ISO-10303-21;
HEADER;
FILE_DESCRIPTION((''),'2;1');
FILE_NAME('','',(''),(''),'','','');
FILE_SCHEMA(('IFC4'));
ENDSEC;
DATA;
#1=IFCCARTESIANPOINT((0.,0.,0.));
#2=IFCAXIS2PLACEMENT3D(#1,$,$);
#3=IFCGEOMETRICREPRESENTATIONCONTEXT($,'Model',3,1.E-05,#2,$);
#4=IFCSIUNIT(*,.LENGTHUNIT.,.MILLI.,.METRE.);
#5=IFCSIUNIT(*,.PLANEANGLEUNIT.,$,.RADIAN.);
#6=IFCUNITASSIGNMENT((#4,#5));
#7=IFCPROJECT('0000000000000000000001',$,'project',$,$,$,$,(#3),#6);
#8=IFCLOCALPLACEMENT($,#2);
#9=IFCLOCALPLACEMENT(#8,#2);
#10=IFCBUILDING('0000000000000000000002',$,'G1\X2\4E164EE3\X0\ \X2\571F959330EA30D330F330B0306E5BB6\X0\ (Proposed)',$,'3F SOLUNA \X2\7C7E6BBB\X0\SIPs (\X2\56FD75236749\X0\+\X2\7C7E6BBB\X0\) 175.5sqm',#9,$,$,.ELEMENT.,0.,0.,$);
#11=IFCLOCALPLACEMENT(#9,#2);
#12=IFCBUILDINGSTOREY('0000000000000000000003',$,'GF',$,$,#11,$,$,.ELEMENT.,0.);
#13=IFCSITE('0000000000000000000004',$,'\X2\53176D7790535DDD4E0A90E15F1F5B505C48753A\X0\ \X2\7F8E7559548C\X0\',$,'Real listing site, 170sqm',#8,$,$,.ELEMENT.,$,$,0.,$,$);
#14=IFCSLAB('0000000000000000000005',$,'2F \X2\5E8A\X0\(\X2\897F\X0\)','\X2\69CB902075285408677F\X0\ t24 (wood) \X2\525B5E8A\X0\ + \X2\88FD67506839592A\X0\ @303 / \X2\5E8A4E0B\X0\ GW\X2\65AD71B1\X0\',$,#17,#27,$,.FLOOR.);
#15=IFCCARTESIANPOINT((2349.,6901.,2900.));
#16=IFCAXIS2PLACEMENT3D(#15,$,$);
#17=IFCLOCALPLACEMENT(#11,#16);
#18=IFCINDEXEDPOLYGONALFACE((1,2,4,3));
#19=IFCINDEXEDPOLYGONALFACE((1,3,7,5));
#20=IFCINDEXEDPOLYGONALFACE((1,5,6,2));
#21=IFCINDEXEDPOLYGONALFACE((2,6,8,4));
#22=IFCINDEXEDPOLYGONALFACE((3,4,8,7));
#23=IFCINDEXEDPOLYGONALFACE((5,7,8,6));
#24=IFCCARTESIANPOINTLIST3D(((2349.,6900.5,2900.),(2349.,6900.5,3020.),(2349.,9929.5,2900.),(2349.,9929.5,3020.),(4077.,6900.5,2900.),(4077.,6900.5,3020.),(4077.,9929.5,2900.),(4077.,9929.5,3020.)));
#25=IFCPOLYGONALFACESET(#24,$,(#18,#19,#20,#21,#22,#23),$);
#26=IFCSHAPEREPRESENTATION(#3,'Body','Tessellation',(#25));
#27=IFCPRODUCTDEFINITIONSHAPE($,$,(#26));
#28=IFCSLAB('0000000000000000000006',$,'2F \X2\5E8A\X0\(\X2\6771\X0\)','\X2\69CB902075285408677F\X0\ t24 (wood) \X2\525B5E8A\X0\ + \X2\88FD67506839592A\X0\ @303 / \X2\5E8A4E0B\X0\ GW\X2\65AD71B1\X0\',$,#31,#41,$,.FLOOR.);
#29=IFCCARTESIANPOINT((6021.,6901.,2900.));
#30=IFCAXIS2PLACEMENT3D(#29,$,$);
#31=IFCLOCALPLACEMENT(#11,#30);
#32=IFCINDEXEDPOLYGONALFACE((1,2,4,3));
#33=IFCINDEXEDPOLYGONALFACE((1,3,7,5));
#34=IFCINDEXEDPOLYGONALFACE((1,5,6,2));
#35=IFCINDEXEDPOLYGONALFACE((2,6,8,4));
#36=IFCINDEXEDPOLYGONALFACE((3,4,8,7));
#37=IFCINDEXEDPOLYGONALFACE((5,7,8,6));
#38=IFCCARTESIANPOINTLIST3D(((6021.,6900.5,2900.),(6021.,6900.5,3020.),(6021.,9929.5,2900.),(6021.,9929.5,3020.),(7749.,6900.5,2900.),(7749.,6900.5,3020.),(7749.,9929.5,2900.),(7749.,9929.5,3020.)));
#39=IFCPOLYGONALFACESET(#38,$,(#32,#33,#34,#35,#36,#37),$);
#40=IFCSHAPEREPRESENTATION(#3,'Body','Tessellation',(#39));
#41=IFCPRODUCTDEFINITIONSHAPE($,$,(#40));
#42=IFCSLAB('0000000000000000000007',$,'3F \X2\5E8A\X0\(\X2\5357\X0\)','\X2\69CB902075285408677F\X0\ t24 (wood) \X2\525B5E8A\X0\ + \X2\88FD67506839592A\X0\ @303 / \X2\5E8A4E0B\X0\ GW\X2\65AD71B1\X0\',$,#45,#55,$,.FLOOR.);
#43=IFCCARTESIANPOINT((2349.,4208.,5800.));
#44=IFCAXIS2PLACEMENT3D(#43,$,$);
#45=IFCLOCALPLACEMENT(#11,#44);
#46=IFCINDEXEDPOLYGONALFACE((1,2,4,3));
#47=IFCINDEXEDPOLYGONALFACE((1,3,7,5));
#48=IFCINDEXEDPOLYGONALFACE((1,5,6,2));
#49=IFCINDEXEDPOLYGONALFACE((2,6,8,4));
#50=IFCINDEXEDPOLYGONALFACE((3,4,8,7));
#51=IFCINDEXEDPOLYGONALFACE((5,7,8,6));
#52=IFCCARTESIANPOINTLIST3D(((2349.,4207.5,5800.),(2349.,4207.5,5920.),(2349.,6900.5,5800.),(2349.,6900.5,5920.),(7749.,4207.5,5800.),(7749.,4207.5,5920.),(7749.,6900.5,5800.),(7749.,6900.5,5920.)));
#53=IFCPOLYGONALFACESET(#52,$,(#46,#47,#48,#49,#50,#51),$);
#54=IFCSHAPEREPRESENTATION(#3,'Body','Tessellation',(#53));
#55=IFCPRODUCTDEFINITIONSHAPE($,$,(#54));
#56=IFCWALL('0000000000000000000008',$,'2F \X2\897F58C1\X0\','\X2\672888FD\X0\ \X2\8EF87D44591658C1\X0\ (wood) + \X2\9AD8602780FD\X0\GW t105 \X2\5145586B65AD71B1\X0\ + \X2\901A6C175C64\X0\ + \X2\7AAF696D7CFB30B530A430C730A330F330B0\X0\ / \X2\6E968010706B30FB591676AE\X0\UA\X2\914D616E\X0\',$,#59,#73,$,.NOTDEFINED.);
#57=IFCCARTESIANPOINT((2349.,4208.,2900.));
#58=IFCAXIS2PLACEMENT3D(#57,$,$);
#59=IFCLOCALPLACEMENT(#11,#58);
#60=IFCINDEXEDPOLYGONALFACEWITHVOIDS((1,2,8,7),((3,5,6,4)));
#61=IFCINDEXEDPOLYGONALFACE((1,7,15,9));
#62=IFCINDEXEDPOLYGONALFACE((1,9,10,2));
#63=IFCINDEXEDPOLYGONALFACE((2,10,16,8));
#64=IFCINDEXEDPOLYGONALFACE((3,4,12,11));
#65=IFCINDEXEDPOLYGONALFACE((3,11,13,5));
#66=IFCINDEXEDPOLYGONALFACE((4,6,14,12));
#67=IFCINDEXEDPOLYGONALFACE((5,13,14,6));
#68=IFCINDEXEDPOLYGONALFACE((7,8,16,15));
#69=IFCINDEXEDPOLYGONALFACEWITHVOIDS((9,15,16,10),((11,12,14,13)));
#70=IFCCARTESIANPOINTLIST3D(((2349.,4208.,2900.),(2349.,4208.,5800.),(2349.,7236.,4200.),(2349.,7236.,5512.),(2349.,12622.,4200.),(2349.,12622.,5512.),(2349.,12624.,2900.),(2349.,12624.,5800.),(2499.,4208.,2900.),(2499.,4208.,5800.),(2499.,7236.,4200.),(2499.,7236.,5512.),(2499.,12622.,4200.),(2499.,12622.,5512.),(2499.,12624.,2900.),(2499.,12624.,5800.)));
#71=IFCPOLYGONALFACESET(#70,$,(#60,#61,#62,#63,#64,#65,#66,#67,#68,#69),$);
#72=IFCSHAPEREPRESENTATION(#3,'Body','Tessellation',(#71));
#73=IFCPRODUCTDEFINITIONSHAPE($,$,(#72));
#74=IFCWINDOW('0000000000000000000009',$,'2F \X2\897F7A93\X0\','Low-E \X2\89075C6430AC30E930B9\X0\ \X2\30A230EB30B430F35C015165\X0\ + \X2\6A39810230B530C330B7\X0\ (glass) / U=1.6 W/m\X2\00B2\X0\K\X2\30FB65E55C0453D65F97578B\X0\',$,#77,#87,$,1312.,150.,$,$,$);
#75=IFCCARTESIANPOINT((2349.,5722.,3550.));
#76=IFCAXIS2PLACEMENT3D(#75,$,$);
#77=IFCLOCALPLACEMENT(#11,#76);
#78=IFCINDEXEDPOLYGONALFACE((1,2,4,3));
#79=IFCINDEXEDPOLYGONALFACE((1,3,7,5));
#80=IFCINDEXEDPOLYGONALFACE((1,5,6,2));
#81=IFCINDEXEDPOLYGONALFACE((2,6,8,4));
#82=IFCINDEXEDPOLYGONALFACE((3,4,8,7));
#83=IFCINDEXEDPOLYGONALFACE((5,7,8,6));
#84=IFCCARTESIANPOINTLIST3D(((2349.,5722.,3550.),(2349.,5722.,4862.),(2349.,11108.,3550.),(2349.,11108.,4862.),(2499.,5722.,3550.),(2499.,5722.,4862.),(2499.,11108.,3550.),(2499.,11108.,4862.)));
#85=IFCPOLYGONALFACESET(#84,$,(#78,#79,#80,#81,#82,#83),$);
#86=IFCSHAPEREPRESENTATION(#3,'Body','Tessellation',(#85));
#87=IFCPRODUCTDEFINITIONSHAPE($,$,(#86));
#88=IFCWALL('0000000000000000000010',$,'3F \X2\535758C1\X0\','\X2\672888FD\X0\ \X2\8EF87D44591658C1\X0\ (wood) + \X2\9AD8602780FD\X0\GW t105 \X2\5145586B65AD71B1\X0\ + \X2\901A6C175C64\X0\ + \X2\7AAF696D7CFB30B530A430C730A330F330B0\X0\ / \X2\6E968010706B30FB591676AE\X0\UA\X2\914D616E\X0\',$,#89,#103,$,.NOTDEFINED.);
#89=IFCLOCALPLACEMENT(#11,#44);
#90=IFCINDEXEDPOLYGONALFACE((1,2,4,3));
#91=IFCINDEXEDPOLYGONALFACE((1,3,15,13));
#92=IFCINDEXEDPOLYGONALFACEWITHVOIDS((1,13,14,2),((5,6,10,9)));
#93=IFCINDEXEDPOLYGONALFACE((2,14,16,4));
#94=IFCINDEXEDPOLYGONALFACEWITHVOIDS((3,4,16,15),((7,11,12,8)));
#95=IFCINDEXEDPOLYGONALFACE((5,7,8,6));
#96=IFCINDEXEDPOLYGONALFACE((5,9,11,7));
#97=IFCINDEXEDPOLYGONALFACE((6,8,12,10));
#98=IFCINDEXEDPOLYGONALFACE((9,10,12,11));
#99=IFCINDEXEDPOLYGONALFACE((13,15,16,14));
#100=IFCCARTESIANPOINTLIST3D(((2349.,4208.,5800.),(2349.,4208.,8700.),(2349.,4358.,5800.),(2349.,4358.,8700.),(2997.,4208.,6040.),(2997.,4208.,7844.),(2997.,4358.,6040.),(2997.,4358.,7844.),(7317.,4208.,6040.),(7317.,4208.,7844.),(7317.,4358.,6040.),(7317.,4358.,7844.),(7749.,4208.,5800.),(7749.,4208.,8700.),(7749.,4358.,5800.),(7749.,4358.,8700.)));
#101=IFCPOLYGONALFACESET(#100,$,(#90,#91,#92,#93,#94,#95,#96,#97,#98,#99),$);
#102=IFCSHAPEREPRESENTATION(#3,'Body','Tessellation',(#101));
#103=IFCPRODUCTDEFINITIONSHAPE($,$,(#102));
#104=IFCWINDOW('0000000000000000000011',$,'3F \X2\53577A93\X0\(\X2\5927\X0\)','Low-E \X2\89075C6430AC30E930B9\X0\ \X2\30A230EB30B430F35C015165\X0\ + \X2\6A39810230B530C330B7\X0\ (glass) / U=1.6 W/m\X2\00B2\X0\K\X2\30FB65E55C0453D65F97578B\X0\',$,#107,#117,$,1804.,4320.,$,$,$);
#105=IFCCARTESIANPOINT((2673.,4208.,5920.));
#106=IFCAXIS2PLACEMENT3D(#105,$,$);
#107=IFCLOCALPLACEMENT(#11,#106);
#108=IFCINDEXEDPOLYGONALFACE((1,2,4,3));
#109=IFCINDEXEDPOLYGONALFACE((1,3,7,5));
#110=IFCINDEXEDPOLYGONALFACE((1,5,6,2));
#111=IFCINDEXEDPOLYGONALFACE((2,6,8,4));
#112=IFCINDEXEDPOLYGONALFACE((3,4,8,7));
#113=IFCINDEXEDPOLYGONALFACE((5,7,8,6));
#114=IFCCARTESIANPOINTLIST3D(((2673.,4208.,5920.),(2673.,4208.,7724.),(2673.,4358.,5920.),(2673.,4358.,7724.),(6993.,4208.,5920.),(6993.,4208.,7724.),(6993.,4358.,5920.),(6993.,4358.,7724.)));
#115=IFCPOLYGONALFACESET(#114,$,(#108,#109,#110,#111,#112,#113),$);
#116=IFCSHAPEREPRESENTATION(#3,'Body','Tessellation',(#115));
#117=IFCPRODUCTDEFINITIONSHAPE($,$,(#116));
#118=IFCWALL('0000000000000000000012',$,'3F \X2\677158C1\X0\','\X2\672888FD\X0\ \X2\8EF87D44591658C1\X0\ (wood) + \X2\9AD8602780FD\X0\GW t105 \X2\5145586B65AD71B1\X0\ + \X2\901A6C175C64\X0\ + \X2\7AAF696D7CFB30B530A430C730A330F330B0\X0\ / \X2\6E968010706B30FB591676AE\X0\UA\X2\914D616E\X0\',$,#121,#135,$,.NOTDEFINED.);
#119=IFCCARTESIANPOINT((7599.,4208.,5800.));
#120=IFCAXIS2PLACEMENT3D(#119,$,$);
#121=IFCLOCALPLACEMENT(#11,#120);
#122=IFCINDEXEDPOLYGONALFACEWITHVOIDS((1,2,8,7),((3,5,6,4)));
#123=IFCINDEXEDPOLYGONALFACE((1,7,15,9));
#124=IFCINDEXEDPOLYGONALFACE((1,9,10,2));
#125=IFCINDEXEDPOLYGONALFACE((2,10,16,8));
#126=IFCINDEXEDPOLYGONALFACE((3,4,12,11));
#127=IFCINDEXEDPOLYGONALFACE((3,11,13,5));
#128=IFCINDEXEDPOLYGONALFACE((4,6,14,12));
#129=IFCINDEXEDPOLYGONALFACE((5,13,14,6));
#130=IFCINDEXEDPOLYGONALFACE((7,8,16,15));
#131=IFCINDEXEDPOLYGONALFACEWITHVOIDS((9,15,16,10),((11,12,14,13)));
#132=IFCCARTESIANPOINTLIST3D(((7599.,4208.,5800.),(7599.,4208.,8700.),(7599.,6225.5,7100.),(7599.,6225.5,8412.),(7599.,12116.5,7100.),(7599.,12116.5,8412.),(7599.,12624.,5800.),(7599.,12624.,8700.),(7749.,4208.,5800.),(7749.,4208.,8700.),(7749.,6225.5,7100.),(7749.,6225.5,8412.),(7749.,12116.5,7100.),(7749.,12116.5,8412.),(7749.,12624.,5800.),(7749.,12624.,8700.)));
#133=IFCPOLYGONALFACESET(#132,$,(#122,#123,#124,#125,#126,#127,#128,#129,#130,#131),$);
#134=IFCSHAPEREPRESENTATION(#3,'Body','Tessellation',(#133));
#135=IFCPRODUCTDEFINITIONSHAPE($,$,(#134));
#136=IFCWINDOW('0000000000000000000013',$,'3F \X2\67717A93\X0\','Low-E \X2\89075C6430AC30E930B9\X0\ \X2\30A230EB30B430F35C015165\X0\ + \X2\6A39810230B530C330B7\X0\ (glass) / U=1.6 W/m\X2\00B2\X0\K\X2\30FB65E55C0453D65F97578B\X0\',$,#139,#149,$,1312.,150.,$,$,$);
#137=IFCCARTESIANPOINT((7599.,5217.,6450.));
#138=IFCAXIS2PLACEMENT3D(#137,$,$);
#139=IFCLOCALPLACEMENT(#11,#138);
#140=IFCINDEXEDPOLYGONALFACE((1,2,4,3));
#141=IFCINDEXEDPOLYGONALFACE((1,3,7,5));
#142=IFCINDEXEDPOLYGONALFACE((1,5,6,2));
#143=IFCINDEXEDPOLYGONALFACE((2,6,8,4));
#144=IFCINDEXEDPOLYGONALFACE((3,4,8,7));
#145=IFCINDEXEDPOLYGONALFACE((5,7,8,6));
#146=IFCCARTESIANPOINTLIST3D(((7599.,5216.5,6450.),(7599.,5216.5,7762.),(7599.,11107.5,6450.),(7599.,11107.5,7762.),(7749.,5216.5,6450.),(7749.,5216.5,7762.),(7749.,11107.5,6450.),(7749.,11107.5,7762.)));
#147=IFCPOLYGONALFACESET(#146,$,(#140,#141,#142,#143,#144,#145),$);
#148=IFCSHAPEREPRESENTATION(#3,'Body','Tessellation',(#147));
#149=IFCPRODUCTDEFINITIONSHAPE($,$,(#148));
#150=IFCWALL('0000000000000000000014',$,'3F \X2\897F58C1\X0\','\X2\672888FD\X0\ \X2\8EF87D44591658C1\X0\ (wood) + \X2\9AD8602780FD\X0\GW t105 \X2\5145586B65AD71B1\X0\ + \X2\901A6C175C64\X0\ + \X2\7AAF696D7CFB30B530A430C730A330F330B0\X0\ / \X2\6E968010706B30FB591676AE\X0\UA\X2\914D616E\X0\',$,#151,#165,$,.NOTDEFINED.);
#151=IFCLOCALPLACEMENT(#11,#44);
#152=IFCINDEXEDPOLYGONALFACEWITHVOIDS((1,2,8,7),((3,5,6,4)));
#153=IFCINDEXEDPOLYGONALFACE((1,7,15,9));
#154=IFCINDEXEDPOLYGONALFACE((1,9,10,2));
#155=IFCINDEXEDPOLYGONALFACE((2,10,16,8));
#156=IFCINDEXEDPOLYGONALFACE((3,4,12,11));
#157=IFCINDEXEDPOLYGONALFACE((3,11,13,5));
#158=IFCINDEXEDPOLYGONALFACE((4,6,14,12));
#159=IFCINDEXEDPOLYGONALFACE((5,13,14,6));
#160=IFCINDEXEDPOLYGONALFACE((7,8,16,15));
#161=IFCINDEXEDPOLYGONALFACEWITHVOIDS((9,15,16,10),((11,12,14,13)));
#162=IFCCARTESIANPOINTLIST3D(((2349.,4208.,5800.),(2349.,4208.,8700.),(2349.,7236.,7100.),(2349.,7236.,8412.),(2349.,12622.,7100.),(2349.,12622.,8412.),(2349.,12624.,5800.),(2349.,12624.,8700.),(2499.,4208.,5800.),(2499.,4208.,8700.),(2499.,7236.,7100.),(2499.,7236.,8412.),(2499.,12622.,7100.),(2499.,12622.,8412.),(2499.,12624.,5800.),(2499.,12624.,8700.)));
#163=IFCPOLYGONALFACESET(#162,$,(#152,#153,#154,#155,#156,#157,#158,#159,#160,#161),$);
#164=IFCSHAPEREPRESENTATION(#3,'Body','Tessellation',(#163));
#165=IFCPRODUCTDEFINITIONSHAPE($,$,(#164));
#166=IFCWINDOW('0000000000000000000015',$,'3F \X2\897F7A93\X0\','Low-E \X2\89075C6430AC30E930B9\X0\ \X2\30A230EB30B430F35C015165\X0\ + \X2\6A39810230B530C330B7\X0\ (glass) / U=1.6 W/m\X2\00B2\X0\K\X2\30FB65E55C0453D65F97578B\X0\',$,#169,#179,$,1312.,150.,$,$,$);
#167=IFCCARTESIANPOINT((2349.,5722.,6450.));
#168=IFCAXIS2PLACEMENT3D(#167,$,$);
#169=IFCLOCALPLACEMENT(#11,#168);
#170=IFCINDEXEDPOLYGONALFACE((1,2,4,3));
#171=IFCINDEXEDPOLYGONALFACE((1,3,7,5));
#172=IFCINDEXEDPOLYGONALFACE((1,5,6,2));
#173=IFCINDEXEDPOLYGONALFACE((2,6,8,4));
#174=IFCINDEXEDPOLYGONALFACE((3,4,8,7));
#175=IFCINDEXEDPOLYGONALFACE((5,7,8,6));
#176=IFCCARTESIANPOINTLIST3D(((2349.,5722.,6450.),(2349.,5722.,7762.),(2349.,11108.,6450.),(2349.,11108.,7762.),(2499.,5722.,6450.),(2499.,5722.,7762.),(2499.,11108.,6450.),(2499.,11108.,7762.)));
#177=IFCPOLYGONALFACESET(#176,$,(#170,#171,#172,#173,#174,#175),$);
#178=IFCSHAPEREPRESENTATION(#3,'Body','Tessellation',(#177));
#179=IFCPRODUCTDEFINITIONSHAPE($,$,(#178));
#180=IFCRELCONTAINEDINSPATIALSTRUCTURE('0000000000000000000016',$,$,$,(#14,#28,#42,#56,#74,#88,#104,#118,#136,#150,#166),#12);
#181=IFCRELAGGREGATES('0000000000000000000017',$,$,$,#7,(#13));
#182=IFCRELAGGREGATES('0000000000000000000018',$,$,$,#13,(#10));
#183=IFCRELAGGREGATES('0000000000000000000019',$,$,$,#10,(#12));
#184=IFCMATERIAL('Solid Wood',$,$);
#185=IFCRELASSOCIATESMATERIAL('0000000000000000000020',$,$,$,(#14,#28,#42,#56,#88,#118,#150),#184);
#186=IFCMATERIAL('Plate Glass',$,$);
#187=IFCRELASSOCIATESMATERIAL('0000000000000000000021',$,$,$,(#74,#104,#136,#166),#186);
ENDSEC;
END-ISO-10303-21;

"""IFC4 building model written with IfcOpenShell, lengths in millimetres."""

from ifc_helpers import new_model, si_unit, frame, frame_2d, origin, place, context, project, spatial, rectangle, extrude, material, element, fill, save


model = new_model("IFC4")

# Units and contexts
model_context = context("Model", 3, precision=1e-05, world=origin())
ifc_project = project(units=[si_unit("LENGTHUNIT", "METRE", prefix="MILLI"), si_unit("PLANEANGLEUNIT", "RADIAN")], contexts=[model_context])

# Site, building, storey
site_placement = place(None, origin())
site = spatial("IfcSite", under=ifc_project, at=site_placement, Name="北海道川上郡弟子屈町 美留和", ObjectType="Real listing site, 170sqm", CompositionType="ELEMENT", RefElevation=0.0)
building_placement = place(site_placement, origin())
building = spatial("IfcBuilding", under=site, at=building_placement, Name="G1世代 土間リビングの家 (Proposed)", ObjectType="3F SOLUNA 籾殻SIPs (国産杉+籾殻) 175.5sqm", CompositionType="ELEMENT", ElevationOfRefHeight=0.0, ElevationOfTerrain=0.0)
storey_placement = place(building_placement, origin())
storey = spatial("IfcBuildingStorey", under=building, at=storey_placement, Name="GF", CompositionType="ELEMENT", Elevation=0.0)

# Slabs
ifc_material_1 = material(Name="Solid Wood")
slab_1_placement = place(storey_placement, frame((2349.0, 6901.0, 2900.0)))
element("IfcSlab", 1, at=slab_1_placement, inside=storey, material=ifc_material_1, Name="2F 床(西)", Description="構造用合板 t24 (wood) 剛床 + 製材根太 @303 / 床下 GW断熱", PredefinedType="FLOOR", context=model_context, shape_type="SweptSolid", body=[
    extrude(rectangle(XDim=1728.0, YDim=3029.0, at=frame_2d((864.0, 1514.0))), frame((2349.0, 6901.0, 2900.0)), (0.0, 0.0, 1.0), 120.0),
])
slab_2_placement = place(storey_placement, frame((6021.0, 6901.0, 2900.0)))
element("IfcSlab", 2, at=slab_2_placement, inside=storey, material=ifc_material_1, Name="2F 床(東)", Description="構造用合板 t24 (wood) 剛床 + 製材根太 @303 / 床下 GW断熱", PredefinedType="FLOOR", context=model_context, shape_type="SweptSolid", body=[
    extrude(rectangle(XDim=1728.0, YDim=3029.0, at=frame_2d((864.0, 1514.0))), frame((6021.0, 6901.0, 2900.0)), (0.0, 0.0, 1.0), 120.0),
])
slab_3_placement = place(storey_placement, frame((2349.0, 4208.0, 5800.0)))
element("IfcSlab", 3, at=slab_3_placement, inside=storey, material=ifc_material_1, Name="3F 床(南)", Description="構造用合板 t24 (wood) 剛床 + 製材根太 @303 / 床下 GW断熱", PredefinedType="FLOOR", context=model_context, shape_type="SweptSolid", body=[
    extrude(rectangle(XDim=5400.0, YDim=2693.0, at=frame_2d((2700.0, 1346.0))), frame((2349.0, 4208.0, 5800.0)), (0.0, 0.0, 1.0), 120.0),
])

# Walls, openings, windows
wall_1_placement = place(storey_placement, frame((2349.0, 4208.0, 2900.0)))
wall_1 = element("IfcWall", 4, at=wall_1_placement, inside=storey, material=ifc_material_1, Name="2F 西壁", Description="木製 軸組外壁 (wood) + 高性能GW t105 充填断熱 + 通気層 + 窯業系サイディング / 準耐火・外皮UA配慮", PredefinedType="NOTDEFINED", context=model_context, shape_type="SweptSolid", body=[
    extrude(rectangle(XDim=150.0, YDim=8416.0, at=frame_2d((75.0, 4208.0))), frame((2349.0, 4208.0, 2900.0)), (0.0, 0.0, 1.0), 2900.0),
])
opening_1_placement = place(storey_placement, frame((2349.0, 5722.0, 3550.0)))
opening_1 = element("IfcOpeningElement", 5, at=opening_1_placement, cuts=wall_1, PredefinedType="NOTDEFINED", context=model_context, shape_type="SweptSolid", body=[
    extrude(rectangle(XDim=150.0, YDim=5386.0, at=frame_2d((75.0, 2693.0))), frame((2349.0, 5722.0, 3550.0)), (0.0, 0.0, 1.0), 1312.0),
])
ifc_material_2 = material(Name="Plate Glass")
window_1_placement = place(storey_placement, frame((2349.0, 5722.0, 3550.0)))
window_1 = element("IfcWindow", 6, at=window_1_placement, inside=storey, material=ifc_material_2, Name="2F 西窓", Description="Low-E 複層ガラス アルゴン封入 + 樹脂サッシ (glass) / U=1.6 W/m²K・日射取得型", OverallHeight=1312.0, OverallWidth=150.0, context=model_context, shape_type="SweptSolid", body=[
    extrude(rectangle(XDim=150.0, YDim=5386.0, at=frame_2d((75.0, 2693.0))), frame((2349.0, 5722.0, 3550.0)), (0.0, 0.0, 1.0), 1312.0),
])
fill(opening_1, window_1)
wall_2_placement = place(storey_placement, frame((2349.0, 4208.0, 5800.0)))
wall_2 = element("IfcWall", 7, at=wall_2_placement, inside=storey, material=ifc_material_1, Name="3F 南壁", Description="木製 軸組外壁 (wood) + 高性能GW t105 充填断熱 + 通気層 + 窯業系サイディング / 準耐火・外皮UA配慮", PredefinedType="NOTDEFINED", context=model_context, shape_type="SweptSolid", body=[
    extrude(rectangle(XDim=5400.0, YDim=150.0, at=frame_2d((2700.0, 75.0))), frame((2349.0, 4208.0, 5800.0)), (0.0, 0.0, 1.0), 2900.0),
])
opening_2_placement = place(storey_placement, frame((2673.0, 4208.0, 5920.0)))
opening_2 = element("IfcOpeningElement", 8, at=opening_2_placement, cuts=wall_2, PredefinedType="NOTDEFINED", context=model_context, shape_type="SweptSolid", body=[
    extrude(rectangle(XDim=4320.0, YDim=150.0, at=frame_2d((2160.0, 75.0))), frame((2673.0, 4208.0, 5920.0)), (0.0, 0.0, 1.0), 1804.0),
])
window_2_placement = place(storey_placement, frame((2673.0, 4208.0, 5920.0)))
window_2 = element("IfcWindow", 9, at=window_2_placement, inside=storey, material=ifc_material_2, Name="3F 南窓(大)", Description="Low-E 複層ガラス アルゴン封入 + 樹脂サッシ (glass) / U=1.6 W/m²K・日射取得型", OverallHeight=1804.0, OverallWidth=4320.0, context=model_context, shape_type="SweptSolid", body=[
    extrude(rectangle(XDim=4320.0, YDim=150.0, at=frame_2d((2160.0, 75.0))), frame((2673.0, 4208.0, 5920.0)), (0.0, 0.0, 1.0), 1804.0),
])
fill(opening_2, window_2)
wall_3_placement = place(storey_placement, frame((7599.0, 4208.0, 5800.0)))
wall_3 = element("IfcWall", 10, at=wall_3_placement, inside=storey, material=ifc_material_1, Name="3F 東壁", Description="木製 軸組外壁 (wood) + 高性能GW t105 充填断熱 + 通気層 + 窯業系サイディング / 準耐火・外皮UA配慮", PredefinedType="NOTDEFINED", context=model_context, shape_type="SweptSolid", body=[
    extrude(rectangle(XDim=150.0, YDim=8416.0, at=frame_2d((75.0, 4208.0))), frame((7599.0, 4208.0, 5800.0)), (0.0, 0.0, 1.0), 2900.0),
])
opening_3_placement = place(storey_placement, frame((7599.0, 5217.0, 6450.0)))
opening_3 = element("IfcOpeningElement", 11, at=opening_3_placement, cuts=wall_3, PredefinedType="NOTDEFINED", context=model_context, shape_type="SweptSolid", body=[
    extrude(rectangle(XDim=150.0, YDim=5891.0, at=frame_2d((75.0, 2945.0))), frame((7599.0, 5217.0, 6450.0)), (0.0, 0.0, 1.0), 1312.0),
])
window_3_placement = place(storey_placement, frame((7599.0, 5217.0, 6450.0)))
window_3 = element("IfcWindow", 12, at=window_3_placement, inside=storey, material=ifc_material_2, Name="3F 東窓", Description="Low-E 複層ガラス アルゴン封入 + 樹脂サッシ (glass) / U=1.6 W/m²K・日射取得型", OverallHeight=1312.0, OverallWidth=150.0, context=model_context, shape_type="SweptSolid", body=[
    extrude(rectangle(XDim=150.0, YDim=5891.0, at=frame_2d((75.0, 2945.0))), frame((7599.0, 5217.0, 6450.0)), (0.0, 0.0, 1.0), 1312.0),
])
fill(opening_3, window_3)
wall_4_placement = place(storey_placement, frame((2349.0, 4208.0, 5800.0)))
wall_4 = element("IfcWall", 13, at=wall_4_placement, inside=storey, material=ifc_material_1, Name="3F 西壁", Description="木製 軸組外壁 (wood) + 高性能GW t105 充填断熱 + 通気層 + 窯業系サイディング / 準耐火・外皮UA配慮", PredefinedType="NOTDEFINED", context=model_context, shape_type="SweptSolid", body=[
    extrude(rectangle(XDim=150.0, YDim=8416.0, at=frame_2d((75.0, 4208.0))), frame((2349.0, 4208.0, 5800.0)), (0.0, 0.0, 1.0), 2900.0),
])
opening_4_placement = place(storey_placement, frame((2349.0, 5722.0, 6450.0)))
opening_4 = element("IfcOpeningElement", 14, at=opening_4_placement, cuts=wall_4, PredefinedType="NOTDEFINED", context=model_context, shape_type="SweptSolid", body=[
    extrude(rectangle(XDim=150.0, YDim=5386.0, at=frame_2d((75.0, 2693.0))), frame((2349.0, 5722.0, 6450.0)), (0.0, 0.0, 1.0), 1312.0),
])
window_4_placement = place(storey_placement, frame((2349.0, 5722.0, 6450.0)))
window_4 = element("IfcWindow", 15, at=window_4_placement, inside=storey, material=ifc_material_2, Name="3F 西窓", Description="Low-E 複層ガラス アルゴン封入 + 樹脂サッシ (glass) / U=1.6 W/m²K・日射取得型", OverallHeight=1312.0, OverallWidth=150.0, context=model_context, shape_type="SweptSolid", body=[
    extrude(rectangle(XDim=150.0, YDim=5386.0, at=frame_2d((75.0, 2693.0))), frame((2349.0, 5722.0, 6450.0)), (0.0, 0.0, 1.0), 1312.0),
])
fill(opening_4, window_4)

save(model, "model.ifc")
